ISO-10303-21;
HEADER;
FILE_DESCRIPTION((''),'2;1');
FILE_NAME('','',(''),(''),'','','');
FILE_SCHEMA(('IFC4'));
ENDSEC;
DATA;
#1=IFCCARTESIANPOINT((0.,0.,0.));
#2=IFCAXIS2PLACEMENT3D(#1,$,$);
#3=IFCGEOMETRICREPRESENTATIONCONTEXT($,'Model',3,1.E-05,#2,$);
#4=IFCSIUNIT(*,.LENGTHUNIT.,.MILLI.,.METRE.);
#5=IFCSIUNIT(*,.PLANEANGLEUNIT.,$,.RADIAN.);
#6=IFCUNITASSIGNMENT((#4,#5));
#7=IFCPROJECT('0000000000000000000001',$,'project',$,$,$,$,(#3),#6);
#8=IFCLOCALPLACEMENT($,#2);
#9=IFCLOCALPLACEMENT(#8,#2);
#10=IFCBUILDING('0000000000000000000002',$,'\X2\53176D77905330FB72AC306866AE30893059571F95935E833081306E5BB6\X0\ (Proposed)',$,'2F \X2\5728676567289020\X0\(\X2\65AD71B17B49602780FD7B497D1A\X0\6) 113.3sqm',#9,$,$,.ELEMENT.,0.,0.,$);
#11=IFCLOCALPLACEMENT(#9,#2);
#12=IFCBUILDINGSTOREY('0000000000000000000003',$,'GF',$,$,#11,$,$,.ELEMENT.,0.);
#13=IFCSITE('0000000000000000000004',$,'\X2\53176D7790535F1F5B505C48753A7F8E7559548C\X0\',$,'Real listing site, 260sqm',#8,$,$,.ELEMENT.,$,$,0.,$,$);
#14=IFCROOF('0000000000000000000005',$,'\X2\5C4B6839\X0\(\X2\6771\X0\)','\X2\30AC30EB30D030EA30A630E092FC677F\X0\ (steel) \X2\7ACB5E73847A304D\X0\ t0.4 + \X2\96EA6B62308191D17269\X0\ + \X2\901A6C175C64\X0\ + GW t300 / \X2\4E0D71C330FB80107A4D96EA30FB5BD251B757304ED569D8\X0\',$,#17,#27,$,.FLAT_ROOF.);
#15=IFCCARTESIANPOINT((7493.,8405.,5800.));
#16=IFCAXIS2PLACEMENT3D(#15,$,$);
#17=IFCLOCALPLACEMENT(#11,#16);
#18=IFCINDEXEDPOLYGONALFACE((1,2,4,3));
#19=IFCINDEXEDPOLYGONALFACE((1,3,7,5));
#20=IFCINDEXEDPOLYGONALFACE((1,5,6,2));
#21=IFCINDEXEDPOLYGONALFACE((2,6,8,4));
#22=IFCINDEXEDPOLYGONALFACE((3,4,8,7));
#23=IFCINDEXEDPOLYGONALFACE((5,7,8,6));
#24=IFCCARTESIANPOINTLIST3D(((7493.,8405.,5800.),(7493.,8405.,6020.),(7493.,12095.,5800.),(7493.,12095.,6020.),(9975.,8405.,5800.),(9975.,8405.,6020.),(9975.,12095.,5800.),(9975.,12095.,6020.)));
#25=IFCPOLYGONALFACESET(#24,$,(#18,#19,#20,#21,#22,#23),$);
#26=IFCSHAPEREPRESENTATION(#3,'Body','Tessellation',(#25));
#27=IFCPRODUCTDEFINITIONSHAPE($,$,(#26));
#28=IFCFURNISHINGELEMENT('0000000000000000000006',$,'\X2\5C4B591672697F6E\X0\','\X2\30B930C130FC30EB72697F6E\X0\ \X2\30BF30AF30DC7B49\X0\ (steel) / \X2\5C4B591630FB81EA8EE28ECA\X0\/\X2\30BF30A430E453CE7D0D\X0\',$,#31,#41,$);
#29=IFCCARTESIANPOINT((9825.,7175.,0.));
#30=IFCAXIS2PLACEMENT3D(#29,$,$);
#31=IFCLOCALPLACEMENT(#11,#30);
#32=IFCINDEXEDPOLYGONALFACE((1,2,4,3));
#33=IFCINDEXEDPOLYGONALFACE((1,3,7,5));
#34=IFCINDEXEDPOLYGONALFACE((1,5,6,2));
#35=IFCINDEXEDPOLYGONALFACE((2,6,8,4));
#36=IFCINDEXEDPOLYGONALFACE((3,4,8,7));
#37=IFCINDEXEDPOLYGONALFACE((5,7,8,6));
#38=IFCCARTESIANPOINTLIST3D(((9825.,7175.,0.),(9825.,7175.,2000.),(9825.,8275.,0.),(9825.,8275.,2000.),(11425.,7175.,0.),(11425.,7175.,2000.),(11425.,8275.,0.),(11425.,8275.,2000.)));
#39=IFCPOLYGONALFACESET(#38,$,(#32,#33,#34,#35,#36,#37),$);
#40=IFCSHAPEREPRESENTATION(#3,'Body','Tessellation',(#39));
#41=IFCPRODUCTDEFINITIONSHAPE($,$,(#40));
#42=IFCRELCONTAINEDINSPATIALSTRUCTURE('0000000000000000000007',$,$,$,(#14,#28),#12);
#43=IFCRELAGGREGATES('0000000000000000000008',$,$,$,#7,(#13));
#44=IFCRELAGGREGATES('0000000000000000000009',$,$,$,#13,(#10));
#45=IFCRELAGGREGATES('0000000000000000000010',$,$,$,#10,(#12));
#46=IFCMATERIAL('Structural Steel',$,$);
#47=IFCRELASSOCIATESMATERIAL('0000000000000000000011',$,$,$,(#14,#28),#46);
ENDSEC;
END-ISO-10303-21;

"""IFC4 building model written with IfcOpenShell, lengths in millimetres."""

from ifc_helpers import new_model, si_unit, frame, frame_2d, origin, place, context, project, spatial, rectangle, extrude, material, element, save


model = new_model("IFC4")

# Units and contexts
model_context = context("Model", 3, precision=1e-05, world=origin())
ifc_project = project(units=[si_unit("LENGTHUNIT", "METRE", prefix="MILLI"), si_unit("PLANEANGLEUNIT", "RADIAN")], contexts=[model_context])

# Site, building, storey
site_placement = place(None, origin())
site = spatial("IfcSite", under=ifc_project, at=site_placement, Name="北海道弟子屈町美留和", ObjectType="Real listing site, 260sqm", CompositionType="ELEMENT", RefElevation=0.0)
building_placement = place(site_placement, origin())
building = spatial("IfcBuilding", under=site, at=building_placement, Name="北海道・犬と暮らす土間広めの家 (Proposed)", ObjectType="2F 在来木造(断熱等性能等級6) 113.3sqm", CompositionType="ELEMENT", ElevationOfRefHeight=0.0, ElevationOfTerrain=0.0)
storey_placement = place(building_placement, origin())
storey = spatial("IfcBuildingStorey", under=building, at=storey_placement, Name="GF", CompositionType="ELEMENT", Elevation=0.0)

# Roof
ifc_material_1 = material(Name="Structural Steel")
for number, where, name in (
    (1, (7493.0, 8405.0, 5800.0), "屋根(東)"),
):
    element("IfcRoof", number, at=place(storey_placement, frame(where)), inside=storey, material=ifc_material_1, Name=name, Description="ガルバリウム鋼板 (steel) 立平葺き t0.4 + 雪止め金物 + 通気層 + GW t300 / 不燃・耐積雪・寒冷地仕様", PredefinedType="FLAT_ROOF", context=model_context, shape_type="SweptSolid", body=[
        extrude(rectangle(XDim=2482.0, YDim=3690.0, at=frame_2d((1241.0, 1845.0))), frame((7493.0, 8405.0, 5800.0)), (0.0, 0.0, 1.0), 220.0),
    ])

# Furnishing element
furnishing_placement = place(storey_placement, frame((9825.0, 7175.0, 0.0)))
element("IfcFurnishingElement", 2, at=furnishing_placement, inside=storey, material=ifc_material_1, Name="屋外物置", Description="スチール物置 タクボ等 (steel) / 屋外・自転車/タイヤ収納", context=model_context, shape_type="SweptSolid", body=[
    extrude(rectangle(XDim=1600.0, YDim=1100.0, at=frame_2d((800.0, 550.0))), frame((9825.0, 7175.0, 0.0)), (0.0, 0.0, 1.0), 2000.0),
])

save(model, "model.ifc")
